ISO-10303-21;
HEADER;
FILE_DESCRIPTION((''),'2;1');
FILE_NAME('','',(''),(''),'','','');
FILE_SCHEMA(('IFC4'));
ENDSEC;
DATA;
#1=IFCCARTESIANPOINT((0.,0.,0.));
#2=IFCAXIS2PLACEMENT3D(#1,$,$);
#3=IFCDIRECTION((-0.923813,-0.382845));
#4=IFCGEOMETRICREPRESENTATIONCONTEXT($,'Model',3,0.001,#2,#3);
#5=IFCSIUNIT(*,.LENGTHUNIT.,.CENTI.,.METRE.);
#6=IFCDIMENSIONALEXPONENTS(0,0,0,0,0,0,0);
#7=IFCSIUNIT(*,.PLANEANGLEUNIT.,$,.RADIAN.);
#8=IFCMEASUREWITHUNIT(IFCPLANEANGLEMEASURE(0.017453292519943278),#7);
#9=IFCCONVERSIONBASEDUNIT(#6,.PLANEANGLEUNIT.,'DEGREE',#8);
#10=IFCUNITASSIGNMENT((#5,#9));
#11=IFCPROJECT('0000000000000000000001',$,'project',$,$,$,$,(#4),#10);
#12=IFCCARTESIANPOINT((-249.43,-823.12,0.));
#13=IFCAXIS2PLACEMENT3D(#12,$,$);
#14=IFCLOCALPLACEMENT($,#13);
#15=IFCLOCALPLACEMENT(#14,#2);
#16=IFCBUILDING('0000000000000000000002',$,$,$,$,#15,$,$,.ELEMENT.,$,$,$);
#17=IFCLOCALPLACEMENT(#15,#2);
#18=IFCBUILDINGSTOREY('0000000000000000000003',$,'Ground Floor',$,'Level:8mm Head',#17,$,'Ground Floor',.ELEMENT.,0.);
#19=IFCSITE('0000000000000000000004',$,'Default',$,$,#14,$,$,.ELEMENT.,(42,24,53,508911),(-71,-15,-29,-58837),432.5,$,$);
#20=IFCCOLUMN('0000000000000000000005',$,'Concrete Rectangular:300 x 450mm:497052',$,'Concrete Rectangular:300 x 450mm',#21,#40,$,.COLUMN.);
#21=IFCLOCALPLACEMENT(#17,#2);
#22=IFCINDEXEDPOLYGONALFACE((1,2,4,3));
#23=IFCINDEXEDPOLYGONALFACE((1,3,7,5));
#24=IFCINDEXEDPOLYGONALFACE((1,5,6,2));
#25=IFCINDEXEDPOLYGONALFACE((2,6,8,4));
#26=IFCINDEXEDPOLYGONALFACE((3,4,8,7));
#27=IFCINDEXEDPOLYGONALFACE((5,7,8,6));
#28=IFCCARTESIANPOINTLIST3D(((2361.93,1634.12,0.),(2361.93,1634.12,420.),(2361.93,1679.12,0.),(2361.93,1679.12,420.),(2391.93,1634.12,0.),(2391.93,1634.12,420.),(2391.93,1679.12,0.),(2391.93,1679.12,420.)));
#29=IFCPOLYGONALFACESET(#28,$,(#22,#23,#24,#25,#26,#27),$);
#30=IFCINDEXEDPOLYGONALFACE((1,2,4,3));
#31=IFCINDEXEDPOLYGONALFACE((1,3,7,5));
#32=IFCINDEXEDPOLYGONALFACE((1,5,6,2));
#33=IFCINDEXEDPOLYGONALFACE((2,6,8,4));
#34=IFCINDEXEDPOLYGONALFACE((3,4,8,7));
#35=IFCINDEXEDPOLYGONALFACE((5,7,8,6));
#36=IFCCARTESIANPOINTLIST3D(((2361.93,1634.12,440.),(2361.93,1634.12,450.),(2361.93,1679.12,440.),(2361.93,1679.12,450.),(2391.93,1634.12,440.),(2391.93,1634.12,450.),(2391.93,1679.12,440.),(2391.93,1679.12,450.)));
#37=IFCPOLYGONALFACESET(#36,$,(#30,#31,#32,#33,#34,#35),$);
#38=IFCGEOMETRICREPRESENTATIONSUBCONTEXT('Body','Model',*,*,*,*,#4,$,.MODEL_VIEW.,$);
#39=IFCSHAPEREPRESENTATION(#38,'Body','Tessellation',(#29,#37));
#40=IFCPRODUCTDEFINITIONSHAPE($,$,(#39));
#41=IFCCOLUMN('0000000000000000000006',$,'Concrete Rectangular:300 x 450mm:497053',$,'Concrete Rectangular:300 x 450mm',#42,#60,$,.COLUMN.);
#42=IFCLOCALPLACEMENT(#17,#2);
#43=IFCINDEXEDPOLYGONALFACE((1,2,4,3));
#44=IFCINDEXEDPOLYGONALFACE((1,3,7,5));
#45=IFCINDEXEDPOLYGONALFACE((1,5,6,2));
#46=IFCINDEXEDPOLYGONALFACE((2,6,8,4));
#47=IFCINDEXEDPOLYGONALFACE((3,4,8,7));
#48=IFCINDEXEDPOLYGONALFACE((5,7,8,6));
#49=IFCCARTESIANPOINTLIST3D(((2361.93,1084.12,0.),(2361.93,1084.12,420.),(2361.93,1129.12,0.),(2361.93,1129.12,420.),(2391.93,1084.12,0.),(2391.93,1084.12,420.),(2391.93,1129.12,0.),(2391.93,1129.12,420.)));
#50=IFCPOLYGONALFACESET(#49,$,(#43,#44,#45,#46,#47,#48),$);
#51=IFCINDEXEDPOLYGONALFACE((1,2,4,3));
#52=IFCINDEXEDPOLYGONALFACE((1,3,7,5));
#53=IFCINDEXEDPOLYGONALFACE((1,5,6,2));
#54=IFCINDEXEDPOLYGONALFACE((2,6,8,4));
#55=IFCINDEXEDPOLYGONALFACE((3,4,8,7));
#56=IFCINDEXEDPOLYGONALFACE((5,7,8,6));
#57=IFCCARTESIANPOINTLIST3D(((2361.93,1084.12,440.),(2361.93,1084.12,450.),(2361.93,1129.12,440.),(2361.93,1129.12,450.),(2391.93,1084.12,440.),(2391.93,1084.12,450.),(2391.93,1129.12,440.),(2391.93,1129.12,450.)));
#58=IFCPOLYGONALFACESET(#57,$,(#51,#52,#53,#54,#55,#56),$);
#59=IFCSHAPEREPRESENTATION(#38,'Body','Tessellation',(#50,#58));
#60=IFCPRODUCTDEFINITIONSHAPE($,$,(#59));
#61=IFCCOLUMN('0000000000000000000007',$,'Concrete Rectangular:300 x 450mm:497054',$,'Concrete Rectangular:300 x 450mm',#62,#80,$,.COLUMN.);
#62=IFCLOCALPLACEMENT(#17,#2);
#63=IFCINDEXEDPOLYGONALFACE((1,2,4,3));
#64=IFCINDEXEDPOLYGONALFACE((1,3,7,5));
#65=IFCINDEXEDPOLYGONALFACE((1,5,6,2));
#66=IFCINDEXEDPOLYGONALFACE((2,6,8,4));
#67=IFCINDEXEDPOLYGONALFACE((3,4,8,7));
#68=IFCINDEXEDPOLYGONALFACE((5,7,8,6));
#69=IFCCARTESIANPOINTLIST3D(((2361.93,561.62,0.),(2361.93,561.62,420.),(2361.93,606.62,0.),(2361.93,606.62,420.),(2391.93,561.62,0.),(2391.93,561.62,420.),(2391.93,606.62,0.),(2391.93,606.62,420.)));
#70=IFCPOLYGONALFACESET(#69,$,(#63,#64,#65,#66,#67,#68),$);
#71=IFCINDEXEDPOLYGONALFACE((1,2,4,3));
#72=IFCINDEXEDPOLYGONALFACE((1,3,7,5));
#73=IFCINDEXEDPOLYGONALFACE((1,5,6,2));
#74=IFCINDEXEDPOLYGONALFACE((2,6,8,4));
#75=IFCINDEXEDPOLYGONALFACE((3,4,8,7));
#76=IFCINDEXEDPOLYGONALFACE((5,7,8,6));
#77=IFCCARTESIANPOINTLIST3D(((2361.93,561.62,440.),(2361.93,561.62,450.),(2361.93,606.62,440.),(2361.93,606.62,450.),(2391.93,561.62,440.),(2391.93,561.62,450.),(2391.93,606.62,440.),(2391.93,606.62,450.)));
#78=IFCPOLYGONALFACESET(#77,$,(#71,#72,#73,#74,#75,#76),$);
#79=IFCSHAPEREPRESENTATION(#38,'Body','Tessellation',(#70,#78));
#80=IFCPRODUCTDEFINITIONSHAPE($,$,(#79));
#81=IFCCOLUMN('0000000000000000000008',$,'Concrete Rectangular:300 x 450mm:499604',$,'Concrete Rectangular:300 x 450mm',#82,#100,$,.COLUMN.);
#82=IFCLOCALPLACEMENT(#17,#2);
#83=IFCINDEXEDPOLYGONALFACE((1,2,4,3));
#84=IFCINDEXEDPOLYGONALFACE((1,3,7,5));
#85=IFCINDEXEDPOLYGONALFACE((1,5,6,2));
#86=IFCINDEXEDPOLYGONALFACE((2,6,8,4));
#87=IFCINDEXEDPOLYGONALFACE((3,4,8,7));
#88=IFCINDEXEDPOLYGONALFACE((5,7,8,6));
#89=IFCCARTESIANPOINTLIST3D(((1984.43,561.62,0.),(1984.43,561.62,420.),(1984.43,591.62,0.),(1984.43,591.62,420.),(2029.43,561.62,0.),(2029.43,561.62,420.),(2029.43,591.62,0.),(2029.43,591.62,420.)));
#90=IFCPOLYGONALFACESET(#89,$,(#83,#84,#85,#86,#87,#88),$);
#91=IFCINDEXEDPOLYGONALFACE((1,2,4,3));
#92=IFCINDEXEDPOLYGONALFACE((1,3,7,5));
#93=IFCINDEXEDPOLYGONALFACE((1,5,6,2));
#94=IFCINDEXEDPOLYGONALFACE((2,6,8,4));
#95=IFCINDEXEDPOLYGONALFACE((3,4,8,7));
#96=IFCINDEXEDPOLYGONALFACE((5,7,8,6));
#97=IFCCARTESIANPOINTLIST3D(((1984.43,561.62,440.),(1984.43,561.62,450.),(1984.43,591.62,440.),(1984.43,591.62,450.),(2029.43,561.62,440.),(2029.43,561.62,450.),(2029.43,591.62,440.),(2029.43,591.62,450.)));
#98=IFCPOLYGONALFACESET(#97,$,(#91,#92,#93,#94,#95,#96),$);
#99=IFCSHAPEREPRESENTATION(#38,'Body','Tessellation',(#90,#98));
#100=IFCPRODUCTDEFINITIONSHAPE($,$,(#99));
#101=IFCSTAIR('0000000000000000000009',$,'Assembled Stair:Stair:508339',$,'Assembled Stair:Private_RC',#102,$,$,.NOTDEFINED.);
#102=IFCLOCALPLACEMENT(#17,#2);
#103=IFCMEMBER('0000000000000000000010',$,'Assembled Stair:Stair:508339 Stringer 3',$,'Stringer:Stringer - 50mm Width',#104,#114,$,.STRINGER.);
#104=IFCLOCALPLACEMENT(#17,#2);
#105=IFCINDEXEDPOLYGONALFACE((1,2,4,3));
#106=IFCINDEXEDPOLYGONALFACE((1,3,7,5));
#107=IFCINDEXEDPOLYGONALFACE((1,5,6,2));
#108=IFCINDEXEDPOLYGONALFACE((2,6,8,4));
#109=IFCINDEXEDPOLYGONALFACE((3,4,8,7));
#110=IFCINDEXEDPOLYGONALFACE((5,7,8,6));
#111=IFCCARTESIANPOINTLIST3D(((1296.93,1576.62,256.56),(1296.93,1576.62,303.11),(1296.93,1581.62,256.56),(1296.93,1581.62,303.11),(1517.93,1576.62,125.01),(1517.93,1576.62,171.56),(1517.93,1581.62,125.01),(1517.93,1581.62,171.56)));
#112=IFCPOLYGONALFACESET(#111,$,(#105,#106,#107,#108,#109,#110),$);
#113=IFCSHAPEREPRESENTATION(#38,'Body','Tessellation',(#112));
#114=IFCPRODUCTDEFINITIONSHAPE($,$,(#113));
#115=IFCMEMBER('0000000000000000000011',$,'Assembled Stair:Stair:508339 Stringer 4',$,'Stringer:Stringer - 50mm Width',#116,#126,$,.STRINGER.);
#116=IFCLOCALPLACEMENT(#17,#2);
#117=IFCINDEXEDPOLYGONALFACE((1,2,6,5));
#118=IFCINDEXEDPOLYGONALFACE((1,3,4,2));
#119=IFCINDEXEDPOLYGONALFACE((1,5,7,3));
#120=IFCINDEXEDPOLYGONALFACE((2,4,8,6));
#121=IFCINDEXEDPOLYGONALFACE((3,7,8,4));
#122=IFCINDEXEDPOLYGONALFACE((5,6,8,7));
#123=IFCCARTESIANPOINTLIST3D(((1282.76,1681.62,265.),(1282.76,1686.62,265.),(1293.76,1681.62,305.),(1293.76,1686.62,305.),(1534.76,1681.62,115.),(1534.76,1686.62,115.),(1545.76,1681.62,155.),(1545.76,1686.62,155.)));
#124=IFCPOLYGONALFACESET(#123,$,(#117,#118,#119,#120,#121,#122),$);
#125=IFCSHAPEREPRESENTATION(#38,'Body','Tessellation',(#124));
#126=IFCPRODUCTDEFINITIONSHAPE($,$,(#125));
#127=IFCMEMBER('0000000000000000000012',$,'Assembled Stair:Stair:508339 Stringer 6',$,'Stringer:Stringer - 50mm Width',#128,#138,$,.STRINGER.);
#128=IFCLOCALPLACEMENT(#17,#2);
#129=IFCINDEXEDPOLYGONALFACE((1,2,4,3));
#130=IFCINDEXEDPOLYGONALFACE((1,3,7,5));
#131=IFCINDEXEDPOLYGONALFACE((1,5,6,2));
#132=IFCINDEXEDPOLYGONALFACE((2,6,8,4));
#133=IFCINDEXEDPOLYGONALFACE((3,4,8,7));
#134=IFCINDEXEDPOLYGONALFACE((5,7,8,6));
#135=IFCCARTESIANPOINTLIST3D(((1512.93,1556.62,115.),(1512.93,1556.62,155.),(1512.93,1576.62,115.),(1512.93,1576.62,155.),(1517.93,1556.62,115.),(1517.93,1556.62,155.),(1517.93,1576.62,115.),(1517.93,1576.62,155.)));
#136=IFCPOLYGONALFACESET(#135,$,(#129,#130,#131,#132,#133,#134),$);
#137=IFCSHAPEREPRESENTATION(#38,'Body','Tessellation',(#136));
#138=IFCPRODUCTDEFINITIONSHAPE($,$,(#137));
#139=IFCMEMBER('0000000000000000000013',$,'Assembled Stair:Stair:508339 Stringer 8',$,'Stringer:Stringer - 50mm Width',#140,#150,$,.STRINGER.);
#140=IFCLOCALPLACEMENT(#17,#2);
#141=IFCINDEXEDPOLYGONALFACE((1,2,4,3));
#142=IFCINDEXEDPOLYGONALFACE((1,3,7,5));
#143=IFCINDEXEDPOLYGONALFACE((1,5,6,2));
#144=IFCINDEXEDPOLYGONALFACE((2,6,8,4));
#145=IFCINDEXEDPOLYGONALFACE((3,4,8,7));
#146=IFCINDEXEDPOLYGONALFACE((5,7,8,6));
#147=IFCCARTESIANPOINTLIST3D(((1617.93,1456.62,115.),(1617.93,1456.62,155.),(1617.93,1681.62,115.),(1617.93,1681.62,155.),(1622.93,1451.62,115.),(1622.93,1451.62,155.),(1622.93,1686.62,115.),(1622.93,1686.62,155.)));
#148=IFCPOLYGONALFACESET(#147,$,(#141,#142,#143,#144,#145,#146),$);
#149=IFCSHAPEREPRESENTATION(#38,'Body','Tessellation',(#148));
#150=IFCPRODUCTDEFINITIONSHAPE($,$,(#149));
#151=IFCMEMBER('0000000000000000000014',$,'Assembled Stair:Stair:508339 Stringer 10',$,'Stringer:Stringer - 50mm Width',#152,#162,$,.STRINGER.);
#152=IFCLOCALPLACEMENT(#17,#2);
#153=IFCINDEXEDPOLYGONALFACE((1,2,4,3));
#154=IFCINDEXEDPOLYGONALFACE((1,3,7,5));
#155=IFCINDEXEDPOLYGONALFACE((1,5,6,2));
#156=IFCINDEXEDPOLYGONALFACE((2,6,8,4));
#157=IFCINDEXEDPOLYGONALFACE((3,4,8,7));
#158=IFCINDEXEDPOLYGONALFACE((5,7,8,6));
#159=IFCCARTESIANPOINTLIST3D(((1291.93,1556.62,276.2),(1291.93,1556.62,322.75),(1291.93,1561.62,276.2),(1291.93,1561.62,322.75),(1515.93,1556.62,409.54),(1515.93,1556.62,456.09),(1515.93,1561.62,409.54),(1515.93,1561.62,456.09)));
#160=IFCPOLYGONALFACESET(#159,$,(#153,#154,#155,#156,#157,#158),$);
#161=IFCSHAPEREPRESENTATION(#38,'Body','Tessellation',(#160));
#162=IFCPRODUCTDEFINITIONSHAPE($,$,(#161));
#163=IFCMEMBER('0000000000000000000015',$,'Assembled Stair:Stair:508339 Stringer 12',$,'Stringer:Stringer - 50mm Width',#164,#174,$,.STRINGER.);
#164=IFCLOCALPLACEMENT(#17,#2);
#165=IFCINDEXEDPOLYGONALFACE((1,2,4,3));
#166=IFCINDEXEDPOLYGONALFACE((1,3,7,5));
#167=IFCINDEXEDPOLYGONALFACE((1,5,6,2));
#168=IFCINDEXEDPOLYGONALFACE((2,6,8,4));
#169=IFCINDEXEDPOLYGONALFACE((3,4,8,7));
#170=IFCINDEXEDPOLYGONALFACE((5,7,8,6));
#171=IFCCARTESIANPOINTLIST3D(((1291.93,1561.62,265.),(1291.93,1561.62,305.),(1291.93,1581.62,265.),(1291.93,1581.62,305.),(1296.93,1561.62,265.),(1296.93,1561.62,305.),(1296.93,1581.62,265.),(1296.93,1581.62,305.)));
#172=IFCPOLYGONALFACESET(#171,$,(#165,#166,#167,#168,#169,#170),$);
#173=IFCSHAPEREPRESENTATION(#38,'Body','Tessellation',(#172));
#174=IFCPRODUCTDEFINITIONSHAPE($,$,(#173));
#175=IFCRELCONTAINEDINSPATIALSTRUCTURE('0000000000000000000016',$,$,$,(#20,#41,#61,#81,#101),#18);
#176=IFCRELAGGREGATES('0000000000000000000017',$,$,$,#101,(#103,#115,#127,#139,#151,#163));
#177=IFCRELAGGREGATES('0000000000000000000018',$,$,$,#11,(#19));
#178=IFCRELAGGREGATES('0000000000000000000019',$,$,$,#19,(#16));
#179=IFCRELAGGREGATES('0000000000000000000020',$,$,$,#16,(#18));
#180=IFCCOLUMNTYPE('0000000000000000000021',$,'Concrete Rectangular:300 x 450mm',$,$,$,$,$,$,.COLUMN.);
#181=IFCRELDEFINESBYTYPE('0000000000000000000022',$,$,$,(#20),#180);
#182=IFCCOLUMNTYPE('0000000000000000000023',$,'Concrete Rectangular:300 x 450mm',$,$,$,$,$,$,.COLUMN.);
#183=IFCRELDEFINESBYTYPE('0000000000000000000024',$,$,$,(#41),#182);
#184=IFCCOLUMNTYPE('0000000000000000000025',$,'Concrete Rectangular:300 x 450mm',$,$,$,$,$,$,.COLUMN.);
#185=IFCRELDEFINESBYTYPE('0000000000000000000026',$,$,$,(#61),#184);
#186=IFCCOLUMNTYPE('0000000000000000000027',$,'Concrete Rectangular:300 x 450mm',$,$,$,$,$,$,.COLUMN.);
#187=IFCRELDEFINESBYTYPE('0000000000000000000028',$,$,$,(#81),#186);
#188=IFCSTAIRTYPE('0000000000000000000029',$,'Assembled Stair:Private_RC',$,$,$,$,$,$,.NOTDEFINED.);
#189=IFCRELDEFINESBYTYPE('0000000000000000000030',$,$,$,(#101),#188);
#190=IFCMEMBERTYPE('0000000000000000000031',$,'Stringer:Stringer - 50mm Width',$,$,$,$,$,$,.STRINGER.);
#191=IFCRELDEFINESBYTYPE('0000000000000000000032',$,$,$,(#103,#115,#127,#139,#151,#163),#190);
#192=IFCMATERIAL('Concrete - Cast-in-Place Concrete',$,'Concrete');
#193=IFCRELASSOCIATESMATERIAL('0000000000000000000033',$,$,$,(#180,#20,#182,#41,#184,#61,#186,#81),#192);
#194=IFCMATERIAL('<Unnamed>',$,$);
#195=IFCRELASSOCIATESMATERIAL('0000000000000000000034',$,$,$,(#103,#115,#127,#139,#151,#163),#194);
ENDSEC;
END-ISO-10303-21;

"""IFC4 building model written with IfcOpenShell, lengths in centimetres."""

from ifc_helpers import new_model, entity, si_unit, converted_unit, direction, frame, origin, place, context, subcontext, project, spatial, indexed_curve, outline, extrude, source, transform, mapped, material, type_object, type_shapes, element, aggregate, save


model = new_model("IFC4")

# Units and contexts
model_context = context("Model", 3, precision=0.001, world=origin(), true_north=direction((-0.923813, -0.382845)))
body_context = subcontext(model_context, "Body", "Model", "MODEL_VIEW")
ifc_project = project(units=[si_unit("LENGTHUNIT", "METRE", prefix="CENTI"), converted_unit("PLANEANGLEUNIT", "DEGREE", entity("IfcPlaneAngleMeasure", 0.017453292519943278), si_unit("PLANEANGLEUNIT", "RADIAN"), dimensions=[0, 0, 0, 0, 0, 0, 0])], contexts=[model_context])

# Site, building, storey
site_placement = place(None, frame((-249.43, -823.12, 0.0)))
site = spatial("IfcSite", under=ifc_project, at=site_placement, Name="Default", CompositionType="ELEMENT", RefLatitude=(42, 24, 53, 508911), RefLongitude=(-71, -15, -29, -58837), RefElevation=432.5)
building_placement = place(site_placement, origin())
building = spatial("IfcBuilding", under=site, at=building_placement, CompositionType="ELEMENT")
storey_placement = place(building_placement, origin())
storey = spatial("IfcBuildingStorey", under=building, at=storey_placement, Name="Ground Floor", ObjectType="Level:8mm Head", LongName="Ground Floor", CompositionType="ELEMENT", Elevation=0.0)

# Columns
ifc_material_1 = material(Name="Concrete - Cast-in-Place Concrete", Category="Concrete")
column_type_1 = type_object("IfcColumnType", Name="Concrete Rectangular:300 x 450mm", PredefinedType="COLUMN", material=ifc_material_1)
shared_shape_1 = source(origin(), body_context, "Body", "SweptSolid", [
    extrude(outline(indexed_curve([(-210.0, -22.5), (210.0, -22.5), (210.0, 22.5), (-210.0, 22.5), (-210.0, -22.5)], self_intersect=False)), frame((2361.93, 1656.62, 210.0), z_axis=(1.0, 0.0, 0.0), x_axis=(0.0, 0.0, 1.0)), (0.0, 0.0, 1.0), 30.0),
    extrude(outline(indexed_curve([(-5.0, -22.5), (5.0, -22.5), (5.0, 22.5), (-5.0, 22.5), (-5.0, -22.5)], self_intersect=False)), frame((2361.93, 1656.62, 445.0), z_axis=(1.0, 0.0, 0.0), x_axis=(0.0, 0.0, -1.0)), (0.0, 0.0, 1.0), 30.0),
])
type_shapes(column_type_1, [shared_shape_1])
column_1_placement = place(storey_placement, origin())
element("IfcColumn", 1, at=column_1_placement, inside=storey, type_object=column_type_1, material=ifc_material_1, Name="Concrete Rectangular:300 x 450mm:497052", ObjectType="Concrete Rectangular:300 x 450mm", PredefinedType="COLUMN", context=body_context, shape_type="MappedRepresentation", body=[
    mapped(shared_shape_1, transform((0.0, 0.0, 0.0), scale=1.0)),
])
column_type_2 = type_object("IfcColumnType", Name="Concrete Rectangular:300 x 450mm", PredefinedType="COLUMN", material=ifc_material_1)
shared_shape_2 = source(origin(), body_context, "Body", "SweptSolid", [
    extrude(outline(indexed_curve([(-210.0, -22.5), (210.0, -22.5), (210.0, 22.5), (-210.0, 22.5), (-210.0, -22.5)], self_intersect=False)), frame((2361.93, 1106.62, 210.0), z_axis=(1.0, 0.0, 0.0), x_axis=(0.0, 0.0, 1.0)), (0.0, 0.0, 1.0), 30.0),
    extrude(outline(indexed_curve([(-5.0, -22.5), (5.0, -22.5), (5.0, 22.5), (-5.0, 22.5), (-5.0, -22.5)], self_intersect=False)), frame((2361.93, 1106.62, 445.0), z_axis=(1.0, 0.0, 0.0), x_axis=(0.0, 0.0, -1.0)), (0.0, 0.0, 1.0), 30.0),
])
type_shapes(column_type_2, [shared_shape_2])
column_2_placement = place(storey_placement, origin())
element("IfcColumn", 2, at=column_2_placement, inside=storey, type_object=column_type_2, material=ifc_material_1, Name="Concrete Rectangular:300 x 450mm:497053", ObjectType="Concrete Rectangular:300 x 450mm", PredefinedType="COLUMN", context=body_context, shape_type="MappedRepresentation", body=[
    mapped(shared_shape_2, transform((0.0, 0.0, 0.0), scale=1.0)),
])
column_type_3 = type_object("IfcColumnType", Name="Concrete Rectangular:300 x 450mm", PredefinedType="COLUMN", material=ifc_material_1)
shared_shape_3 = source(origin(), body_context, "Body", "SweptSolid", [
    extrude(outline(indexed_curve([(-210.0, -22.5), (210.0, -22.5), (210.0, 22.5), (-210.0, 22.5), (-210.0, -22.5)], self_intersect=False)), frame((2361.93, 584.12, 210.0), z_axis=(1.0, 0.0, 0.0), x_axis=(0.0, 0.0, 1.0)), (0.0, 0.0, 1.0), 30.0),
    extrude(outline(indexed_curve([(-5.0, -22.5), (5.0, -22.5), (5.0, 22.5), (-5.0, 22.5), (-5.0, -22.5)], self_intersect=False)), frame((2361.93, 584.12, 445.0), z_axis=(1.0, 0.0, 0.0), x_axis=(0.0, 0.0, -1.0)), (0.0, 0.0, 1.0), 30.0),
])
type_shapes(column_type_3, [shared_shape_3])
column_3_placement = place(storey_placement, origin())
element("IfcColumn", 3, at=column_3_placement, inside=storey, type_object=column_type_3, material=ifc_material_1, Name="Concrete Rectangular:300 x 450mm:497054", ObjectType="Concrete Rectangular:300 x 450mm", PredefinedType="COLUMN", context=body_context, shape_type="MappedRepresentation", body=[
    mapped(shared_shape_3, transform((0.0, 0.0, 0.0), scale=1.0)),
])
column_type_4 = type_object("IfcColumnType", Name="Concrete Rectangular:300 x 450mm", PredefinedType="COLUMN", material=ifc_material_1)
shared_shape_4 = source(origin(), body_context, "Body", "SweptSolid", [
    extrude(outline(indexed_curve([(-15.0, -22.5), (15.0, -22.5), (15.0, 22.5), (-15.0, 22.5), (-15.0, -22.5)], self_intersect=False)), frame((2006.93, 576.62, 0.0), z_axis=(0.0, 0.0, 1.0), x_axis=(0.0, -1.0, 0.0)), (0.0, 0.0, 1.0), 420.0),
    extrude(outline(indexed_curve([(-15.0, -22.5), (15.0, -22.5), (15.0, 22.5), (-15.0, 22.5), (-15.0, -22.5)], self_intersect=False)), frame((2006.93, 576.62, 440.0), z_axis=(0.0, 0.0, 1.0), x_axis=(0.0, -1.0, 0.0)), (0.0, 0.0, 1.0), 10.0),
])
type_shapes(column_type_4, [shared_shape_4])
column_4_placement = place(storey_placement, origin())
element("IfcColumn", 4, at=column_4_placement, inside=storey, type_object=column_type_4, material=ifc_material_1, Name="Concrete Rectangular:300 x 450mm:499604", ObjectType="Concrete Rectangular:300 x 450mm", PredefinedType="COLUMN", context=body_context, shape_type="MappedRepresentation", body=[
    mapped(shared_shape_4, transform((0.0, 0.0, 0.0), scale=1.0)),
])

# Stair, members
stair_type = type_object("IfcStairType", Name="Assembled Stair:Private_RC", PredefinedType="NOTDEFINED")
stair_placement = place(storey_placement, origin())
stair = element("IfcStair", 5, at=stair_placement, inside=storey, type_object=stair_type, Name="Assembled Stair:Stair:508339", ObjectType="Assembled Stair:Private_RC", PredefinedType="NOTDEFINED")
ifc_material_2 = material(Name="<Unnamed>")
member_type = type_object("IfcMemberType", Name="Stringer:Stringer - 50mm Width", PredefinedType="STRINGER")
member_1_placement = place(stair_placement, origin())
member_1 = element("IfcMember", 6, at=member_1_placement, type_object=member_type, material=ifc_material_2, Name="Assembled Stair:Stair:508339 Stringer 3", ObjectType="Stringer:Stringer - 50mm Width", PredefinedType="STRINGER", context=body_context, shape_type="SweptSolid", body=[
    extrude(outline(indexed_curve([(-140.5, -20.0), (116.69, -20.0), (140.5, 20.0), (-116.69, 20.0), (-140.5, -20.0)], self_intersect=False)), frame((1407.43, 1576.62, 214.06), z_axis=(0.0, 1.0, 0.0), x_axis=(-0.859293, 0.0, 0.511484)), (0.0, 0.0, 1.0), 5.0),
])
member_2_placement = place(stair_placement, origin())
member_2 = element("IfcMember", 7, at=member_2_placement, type_object=member_type, material=ifc_material_2, Name="Assembled Stair:Stair:508339 Stringer 4", ObjectType="Stringer:Stringer - 50mm Width", PredefinedType="STRINGER", context=body_context, shape_type="SweptSolid", body=[
    extrude(outline(indexed_curve([(-152.13, -20.0), (141.13, -20.0), (152.13, 20.0), (-141.13, 20.0), (-152.13, -20.0)], self_intersect=False)), frame((1414.26, 1681.62, 210.0), z_axis=(0.0, 1.0, 0.0), x_axis=(-0.859293, 0.0, 0.511484)), (0.0, 0.0, 1.0), 5.0),
])
member_3_placement = place(stair_placement, origin())
member_3 = element("IfcMember", 8, at=member_3_placement, type_object=member_type, material=ifc_material_2, Name="Assembled Stair:Stair:508339 Stringer 6", ObjectType="Stringer:Stringer - 50mm Width", PredefinedType="STRINGER", context=body_context, shape_type="SweptSolid", body=[
    extrude(outline(indexed_curve([(-10.0, -2.5), (10.0, -2.5), (10.0, 2.5), (-10.0, 2.5), (-10.0, -2.5)], self_intersect=False)), frame((1515.43, 1566.62, 115.0), z_axis=(0.0, 0.0, 1.0), x_axis=(0.0, -1.0, 0.0)), (0.0, 0.0, 1.0), 40.0),
])
member_4_placement = place(stair_placement, origin())
member_4 = element("IfcMember", 9, at=member_4_placement, type_object=member_type, material=ifc_material_2, Name="Assembled Stair:Stair:508339 Stringer 8", ObjectType="Stringer:Stringer - 50mm Width", PredefinedType="STRINGER", context=body_context, shape_type="SweptSolid", body=[
    extrude(outline(indexed_curve([(-117.5, -2.5), (117.5, -2.5), (112.5, 2.5), (-112.5, 2.5), (-117.5, -2.5)], self_intersect=False)), frame((1620.43, 1569.12, 115.0), z_axis=(0.0, 0.0, 1.0), x_axis=(0.0, 1.0, 0.0)), (0.0, 0.0, 1.0), 40.0),
])
member_5_placement = place(stair_placement, origin())
member_5 = element("IfcMember", 10, at=member_5_placement, type_object=member_type, material=ifc_material_2, Name="Assembled Stair:Stair:508339 Stringer 10", ObjectType="Stringer:Stringer - 50mm Width", PredefinedType="STRINGER", context=body_context, shape_type="SweptSolid", body=[
    extrude(outline(indexed_curve([(-118.43, -20.0), (142.24, -20.0), (118.43, 20.0), (-142.24, 20.0), (-118.43, -20.0)], self_intersect=False)), frame((1403.93, 1556.62, 366.15), z_axis=(0.0, 1.0, 0.0), x_axis=(0.859293, 0.0, 0.511484)), (0.0, 0.0, 1.0), 5.0),
])
member_6_placement = place(stair_placement, origin())
member_6 = element("IfcMember", 11, at=member_6_placement, type_object=member_type, material=ifc_material_2, Name="Assembled Stair:Stair:508339 Stringer 12", ObjectType="Stringer:Stringer - 50mm Width", PredefinedType="STRINGER", context=body_context, shape_type="SweptSolid", body=[
    extrude(outline(indexed_curve([(-10.0, -2.5), (10.0, -2.5), (10.0, 2.5), (-10.0, 2.5), (-10.0, -2.5)], self_intersect=False)), frame((1294.43, 1571.62, 265.0), z_axis=(0.0, 0.0, 1.0), x_axis=(0.0, 1.0, 0.0)), (0.0, 0.0, 1.0), 40.0),
])

aggregate(stair, [member_1, member_2, member_3, member_4, member_5, member_6])

save(model, "model.ifc")
